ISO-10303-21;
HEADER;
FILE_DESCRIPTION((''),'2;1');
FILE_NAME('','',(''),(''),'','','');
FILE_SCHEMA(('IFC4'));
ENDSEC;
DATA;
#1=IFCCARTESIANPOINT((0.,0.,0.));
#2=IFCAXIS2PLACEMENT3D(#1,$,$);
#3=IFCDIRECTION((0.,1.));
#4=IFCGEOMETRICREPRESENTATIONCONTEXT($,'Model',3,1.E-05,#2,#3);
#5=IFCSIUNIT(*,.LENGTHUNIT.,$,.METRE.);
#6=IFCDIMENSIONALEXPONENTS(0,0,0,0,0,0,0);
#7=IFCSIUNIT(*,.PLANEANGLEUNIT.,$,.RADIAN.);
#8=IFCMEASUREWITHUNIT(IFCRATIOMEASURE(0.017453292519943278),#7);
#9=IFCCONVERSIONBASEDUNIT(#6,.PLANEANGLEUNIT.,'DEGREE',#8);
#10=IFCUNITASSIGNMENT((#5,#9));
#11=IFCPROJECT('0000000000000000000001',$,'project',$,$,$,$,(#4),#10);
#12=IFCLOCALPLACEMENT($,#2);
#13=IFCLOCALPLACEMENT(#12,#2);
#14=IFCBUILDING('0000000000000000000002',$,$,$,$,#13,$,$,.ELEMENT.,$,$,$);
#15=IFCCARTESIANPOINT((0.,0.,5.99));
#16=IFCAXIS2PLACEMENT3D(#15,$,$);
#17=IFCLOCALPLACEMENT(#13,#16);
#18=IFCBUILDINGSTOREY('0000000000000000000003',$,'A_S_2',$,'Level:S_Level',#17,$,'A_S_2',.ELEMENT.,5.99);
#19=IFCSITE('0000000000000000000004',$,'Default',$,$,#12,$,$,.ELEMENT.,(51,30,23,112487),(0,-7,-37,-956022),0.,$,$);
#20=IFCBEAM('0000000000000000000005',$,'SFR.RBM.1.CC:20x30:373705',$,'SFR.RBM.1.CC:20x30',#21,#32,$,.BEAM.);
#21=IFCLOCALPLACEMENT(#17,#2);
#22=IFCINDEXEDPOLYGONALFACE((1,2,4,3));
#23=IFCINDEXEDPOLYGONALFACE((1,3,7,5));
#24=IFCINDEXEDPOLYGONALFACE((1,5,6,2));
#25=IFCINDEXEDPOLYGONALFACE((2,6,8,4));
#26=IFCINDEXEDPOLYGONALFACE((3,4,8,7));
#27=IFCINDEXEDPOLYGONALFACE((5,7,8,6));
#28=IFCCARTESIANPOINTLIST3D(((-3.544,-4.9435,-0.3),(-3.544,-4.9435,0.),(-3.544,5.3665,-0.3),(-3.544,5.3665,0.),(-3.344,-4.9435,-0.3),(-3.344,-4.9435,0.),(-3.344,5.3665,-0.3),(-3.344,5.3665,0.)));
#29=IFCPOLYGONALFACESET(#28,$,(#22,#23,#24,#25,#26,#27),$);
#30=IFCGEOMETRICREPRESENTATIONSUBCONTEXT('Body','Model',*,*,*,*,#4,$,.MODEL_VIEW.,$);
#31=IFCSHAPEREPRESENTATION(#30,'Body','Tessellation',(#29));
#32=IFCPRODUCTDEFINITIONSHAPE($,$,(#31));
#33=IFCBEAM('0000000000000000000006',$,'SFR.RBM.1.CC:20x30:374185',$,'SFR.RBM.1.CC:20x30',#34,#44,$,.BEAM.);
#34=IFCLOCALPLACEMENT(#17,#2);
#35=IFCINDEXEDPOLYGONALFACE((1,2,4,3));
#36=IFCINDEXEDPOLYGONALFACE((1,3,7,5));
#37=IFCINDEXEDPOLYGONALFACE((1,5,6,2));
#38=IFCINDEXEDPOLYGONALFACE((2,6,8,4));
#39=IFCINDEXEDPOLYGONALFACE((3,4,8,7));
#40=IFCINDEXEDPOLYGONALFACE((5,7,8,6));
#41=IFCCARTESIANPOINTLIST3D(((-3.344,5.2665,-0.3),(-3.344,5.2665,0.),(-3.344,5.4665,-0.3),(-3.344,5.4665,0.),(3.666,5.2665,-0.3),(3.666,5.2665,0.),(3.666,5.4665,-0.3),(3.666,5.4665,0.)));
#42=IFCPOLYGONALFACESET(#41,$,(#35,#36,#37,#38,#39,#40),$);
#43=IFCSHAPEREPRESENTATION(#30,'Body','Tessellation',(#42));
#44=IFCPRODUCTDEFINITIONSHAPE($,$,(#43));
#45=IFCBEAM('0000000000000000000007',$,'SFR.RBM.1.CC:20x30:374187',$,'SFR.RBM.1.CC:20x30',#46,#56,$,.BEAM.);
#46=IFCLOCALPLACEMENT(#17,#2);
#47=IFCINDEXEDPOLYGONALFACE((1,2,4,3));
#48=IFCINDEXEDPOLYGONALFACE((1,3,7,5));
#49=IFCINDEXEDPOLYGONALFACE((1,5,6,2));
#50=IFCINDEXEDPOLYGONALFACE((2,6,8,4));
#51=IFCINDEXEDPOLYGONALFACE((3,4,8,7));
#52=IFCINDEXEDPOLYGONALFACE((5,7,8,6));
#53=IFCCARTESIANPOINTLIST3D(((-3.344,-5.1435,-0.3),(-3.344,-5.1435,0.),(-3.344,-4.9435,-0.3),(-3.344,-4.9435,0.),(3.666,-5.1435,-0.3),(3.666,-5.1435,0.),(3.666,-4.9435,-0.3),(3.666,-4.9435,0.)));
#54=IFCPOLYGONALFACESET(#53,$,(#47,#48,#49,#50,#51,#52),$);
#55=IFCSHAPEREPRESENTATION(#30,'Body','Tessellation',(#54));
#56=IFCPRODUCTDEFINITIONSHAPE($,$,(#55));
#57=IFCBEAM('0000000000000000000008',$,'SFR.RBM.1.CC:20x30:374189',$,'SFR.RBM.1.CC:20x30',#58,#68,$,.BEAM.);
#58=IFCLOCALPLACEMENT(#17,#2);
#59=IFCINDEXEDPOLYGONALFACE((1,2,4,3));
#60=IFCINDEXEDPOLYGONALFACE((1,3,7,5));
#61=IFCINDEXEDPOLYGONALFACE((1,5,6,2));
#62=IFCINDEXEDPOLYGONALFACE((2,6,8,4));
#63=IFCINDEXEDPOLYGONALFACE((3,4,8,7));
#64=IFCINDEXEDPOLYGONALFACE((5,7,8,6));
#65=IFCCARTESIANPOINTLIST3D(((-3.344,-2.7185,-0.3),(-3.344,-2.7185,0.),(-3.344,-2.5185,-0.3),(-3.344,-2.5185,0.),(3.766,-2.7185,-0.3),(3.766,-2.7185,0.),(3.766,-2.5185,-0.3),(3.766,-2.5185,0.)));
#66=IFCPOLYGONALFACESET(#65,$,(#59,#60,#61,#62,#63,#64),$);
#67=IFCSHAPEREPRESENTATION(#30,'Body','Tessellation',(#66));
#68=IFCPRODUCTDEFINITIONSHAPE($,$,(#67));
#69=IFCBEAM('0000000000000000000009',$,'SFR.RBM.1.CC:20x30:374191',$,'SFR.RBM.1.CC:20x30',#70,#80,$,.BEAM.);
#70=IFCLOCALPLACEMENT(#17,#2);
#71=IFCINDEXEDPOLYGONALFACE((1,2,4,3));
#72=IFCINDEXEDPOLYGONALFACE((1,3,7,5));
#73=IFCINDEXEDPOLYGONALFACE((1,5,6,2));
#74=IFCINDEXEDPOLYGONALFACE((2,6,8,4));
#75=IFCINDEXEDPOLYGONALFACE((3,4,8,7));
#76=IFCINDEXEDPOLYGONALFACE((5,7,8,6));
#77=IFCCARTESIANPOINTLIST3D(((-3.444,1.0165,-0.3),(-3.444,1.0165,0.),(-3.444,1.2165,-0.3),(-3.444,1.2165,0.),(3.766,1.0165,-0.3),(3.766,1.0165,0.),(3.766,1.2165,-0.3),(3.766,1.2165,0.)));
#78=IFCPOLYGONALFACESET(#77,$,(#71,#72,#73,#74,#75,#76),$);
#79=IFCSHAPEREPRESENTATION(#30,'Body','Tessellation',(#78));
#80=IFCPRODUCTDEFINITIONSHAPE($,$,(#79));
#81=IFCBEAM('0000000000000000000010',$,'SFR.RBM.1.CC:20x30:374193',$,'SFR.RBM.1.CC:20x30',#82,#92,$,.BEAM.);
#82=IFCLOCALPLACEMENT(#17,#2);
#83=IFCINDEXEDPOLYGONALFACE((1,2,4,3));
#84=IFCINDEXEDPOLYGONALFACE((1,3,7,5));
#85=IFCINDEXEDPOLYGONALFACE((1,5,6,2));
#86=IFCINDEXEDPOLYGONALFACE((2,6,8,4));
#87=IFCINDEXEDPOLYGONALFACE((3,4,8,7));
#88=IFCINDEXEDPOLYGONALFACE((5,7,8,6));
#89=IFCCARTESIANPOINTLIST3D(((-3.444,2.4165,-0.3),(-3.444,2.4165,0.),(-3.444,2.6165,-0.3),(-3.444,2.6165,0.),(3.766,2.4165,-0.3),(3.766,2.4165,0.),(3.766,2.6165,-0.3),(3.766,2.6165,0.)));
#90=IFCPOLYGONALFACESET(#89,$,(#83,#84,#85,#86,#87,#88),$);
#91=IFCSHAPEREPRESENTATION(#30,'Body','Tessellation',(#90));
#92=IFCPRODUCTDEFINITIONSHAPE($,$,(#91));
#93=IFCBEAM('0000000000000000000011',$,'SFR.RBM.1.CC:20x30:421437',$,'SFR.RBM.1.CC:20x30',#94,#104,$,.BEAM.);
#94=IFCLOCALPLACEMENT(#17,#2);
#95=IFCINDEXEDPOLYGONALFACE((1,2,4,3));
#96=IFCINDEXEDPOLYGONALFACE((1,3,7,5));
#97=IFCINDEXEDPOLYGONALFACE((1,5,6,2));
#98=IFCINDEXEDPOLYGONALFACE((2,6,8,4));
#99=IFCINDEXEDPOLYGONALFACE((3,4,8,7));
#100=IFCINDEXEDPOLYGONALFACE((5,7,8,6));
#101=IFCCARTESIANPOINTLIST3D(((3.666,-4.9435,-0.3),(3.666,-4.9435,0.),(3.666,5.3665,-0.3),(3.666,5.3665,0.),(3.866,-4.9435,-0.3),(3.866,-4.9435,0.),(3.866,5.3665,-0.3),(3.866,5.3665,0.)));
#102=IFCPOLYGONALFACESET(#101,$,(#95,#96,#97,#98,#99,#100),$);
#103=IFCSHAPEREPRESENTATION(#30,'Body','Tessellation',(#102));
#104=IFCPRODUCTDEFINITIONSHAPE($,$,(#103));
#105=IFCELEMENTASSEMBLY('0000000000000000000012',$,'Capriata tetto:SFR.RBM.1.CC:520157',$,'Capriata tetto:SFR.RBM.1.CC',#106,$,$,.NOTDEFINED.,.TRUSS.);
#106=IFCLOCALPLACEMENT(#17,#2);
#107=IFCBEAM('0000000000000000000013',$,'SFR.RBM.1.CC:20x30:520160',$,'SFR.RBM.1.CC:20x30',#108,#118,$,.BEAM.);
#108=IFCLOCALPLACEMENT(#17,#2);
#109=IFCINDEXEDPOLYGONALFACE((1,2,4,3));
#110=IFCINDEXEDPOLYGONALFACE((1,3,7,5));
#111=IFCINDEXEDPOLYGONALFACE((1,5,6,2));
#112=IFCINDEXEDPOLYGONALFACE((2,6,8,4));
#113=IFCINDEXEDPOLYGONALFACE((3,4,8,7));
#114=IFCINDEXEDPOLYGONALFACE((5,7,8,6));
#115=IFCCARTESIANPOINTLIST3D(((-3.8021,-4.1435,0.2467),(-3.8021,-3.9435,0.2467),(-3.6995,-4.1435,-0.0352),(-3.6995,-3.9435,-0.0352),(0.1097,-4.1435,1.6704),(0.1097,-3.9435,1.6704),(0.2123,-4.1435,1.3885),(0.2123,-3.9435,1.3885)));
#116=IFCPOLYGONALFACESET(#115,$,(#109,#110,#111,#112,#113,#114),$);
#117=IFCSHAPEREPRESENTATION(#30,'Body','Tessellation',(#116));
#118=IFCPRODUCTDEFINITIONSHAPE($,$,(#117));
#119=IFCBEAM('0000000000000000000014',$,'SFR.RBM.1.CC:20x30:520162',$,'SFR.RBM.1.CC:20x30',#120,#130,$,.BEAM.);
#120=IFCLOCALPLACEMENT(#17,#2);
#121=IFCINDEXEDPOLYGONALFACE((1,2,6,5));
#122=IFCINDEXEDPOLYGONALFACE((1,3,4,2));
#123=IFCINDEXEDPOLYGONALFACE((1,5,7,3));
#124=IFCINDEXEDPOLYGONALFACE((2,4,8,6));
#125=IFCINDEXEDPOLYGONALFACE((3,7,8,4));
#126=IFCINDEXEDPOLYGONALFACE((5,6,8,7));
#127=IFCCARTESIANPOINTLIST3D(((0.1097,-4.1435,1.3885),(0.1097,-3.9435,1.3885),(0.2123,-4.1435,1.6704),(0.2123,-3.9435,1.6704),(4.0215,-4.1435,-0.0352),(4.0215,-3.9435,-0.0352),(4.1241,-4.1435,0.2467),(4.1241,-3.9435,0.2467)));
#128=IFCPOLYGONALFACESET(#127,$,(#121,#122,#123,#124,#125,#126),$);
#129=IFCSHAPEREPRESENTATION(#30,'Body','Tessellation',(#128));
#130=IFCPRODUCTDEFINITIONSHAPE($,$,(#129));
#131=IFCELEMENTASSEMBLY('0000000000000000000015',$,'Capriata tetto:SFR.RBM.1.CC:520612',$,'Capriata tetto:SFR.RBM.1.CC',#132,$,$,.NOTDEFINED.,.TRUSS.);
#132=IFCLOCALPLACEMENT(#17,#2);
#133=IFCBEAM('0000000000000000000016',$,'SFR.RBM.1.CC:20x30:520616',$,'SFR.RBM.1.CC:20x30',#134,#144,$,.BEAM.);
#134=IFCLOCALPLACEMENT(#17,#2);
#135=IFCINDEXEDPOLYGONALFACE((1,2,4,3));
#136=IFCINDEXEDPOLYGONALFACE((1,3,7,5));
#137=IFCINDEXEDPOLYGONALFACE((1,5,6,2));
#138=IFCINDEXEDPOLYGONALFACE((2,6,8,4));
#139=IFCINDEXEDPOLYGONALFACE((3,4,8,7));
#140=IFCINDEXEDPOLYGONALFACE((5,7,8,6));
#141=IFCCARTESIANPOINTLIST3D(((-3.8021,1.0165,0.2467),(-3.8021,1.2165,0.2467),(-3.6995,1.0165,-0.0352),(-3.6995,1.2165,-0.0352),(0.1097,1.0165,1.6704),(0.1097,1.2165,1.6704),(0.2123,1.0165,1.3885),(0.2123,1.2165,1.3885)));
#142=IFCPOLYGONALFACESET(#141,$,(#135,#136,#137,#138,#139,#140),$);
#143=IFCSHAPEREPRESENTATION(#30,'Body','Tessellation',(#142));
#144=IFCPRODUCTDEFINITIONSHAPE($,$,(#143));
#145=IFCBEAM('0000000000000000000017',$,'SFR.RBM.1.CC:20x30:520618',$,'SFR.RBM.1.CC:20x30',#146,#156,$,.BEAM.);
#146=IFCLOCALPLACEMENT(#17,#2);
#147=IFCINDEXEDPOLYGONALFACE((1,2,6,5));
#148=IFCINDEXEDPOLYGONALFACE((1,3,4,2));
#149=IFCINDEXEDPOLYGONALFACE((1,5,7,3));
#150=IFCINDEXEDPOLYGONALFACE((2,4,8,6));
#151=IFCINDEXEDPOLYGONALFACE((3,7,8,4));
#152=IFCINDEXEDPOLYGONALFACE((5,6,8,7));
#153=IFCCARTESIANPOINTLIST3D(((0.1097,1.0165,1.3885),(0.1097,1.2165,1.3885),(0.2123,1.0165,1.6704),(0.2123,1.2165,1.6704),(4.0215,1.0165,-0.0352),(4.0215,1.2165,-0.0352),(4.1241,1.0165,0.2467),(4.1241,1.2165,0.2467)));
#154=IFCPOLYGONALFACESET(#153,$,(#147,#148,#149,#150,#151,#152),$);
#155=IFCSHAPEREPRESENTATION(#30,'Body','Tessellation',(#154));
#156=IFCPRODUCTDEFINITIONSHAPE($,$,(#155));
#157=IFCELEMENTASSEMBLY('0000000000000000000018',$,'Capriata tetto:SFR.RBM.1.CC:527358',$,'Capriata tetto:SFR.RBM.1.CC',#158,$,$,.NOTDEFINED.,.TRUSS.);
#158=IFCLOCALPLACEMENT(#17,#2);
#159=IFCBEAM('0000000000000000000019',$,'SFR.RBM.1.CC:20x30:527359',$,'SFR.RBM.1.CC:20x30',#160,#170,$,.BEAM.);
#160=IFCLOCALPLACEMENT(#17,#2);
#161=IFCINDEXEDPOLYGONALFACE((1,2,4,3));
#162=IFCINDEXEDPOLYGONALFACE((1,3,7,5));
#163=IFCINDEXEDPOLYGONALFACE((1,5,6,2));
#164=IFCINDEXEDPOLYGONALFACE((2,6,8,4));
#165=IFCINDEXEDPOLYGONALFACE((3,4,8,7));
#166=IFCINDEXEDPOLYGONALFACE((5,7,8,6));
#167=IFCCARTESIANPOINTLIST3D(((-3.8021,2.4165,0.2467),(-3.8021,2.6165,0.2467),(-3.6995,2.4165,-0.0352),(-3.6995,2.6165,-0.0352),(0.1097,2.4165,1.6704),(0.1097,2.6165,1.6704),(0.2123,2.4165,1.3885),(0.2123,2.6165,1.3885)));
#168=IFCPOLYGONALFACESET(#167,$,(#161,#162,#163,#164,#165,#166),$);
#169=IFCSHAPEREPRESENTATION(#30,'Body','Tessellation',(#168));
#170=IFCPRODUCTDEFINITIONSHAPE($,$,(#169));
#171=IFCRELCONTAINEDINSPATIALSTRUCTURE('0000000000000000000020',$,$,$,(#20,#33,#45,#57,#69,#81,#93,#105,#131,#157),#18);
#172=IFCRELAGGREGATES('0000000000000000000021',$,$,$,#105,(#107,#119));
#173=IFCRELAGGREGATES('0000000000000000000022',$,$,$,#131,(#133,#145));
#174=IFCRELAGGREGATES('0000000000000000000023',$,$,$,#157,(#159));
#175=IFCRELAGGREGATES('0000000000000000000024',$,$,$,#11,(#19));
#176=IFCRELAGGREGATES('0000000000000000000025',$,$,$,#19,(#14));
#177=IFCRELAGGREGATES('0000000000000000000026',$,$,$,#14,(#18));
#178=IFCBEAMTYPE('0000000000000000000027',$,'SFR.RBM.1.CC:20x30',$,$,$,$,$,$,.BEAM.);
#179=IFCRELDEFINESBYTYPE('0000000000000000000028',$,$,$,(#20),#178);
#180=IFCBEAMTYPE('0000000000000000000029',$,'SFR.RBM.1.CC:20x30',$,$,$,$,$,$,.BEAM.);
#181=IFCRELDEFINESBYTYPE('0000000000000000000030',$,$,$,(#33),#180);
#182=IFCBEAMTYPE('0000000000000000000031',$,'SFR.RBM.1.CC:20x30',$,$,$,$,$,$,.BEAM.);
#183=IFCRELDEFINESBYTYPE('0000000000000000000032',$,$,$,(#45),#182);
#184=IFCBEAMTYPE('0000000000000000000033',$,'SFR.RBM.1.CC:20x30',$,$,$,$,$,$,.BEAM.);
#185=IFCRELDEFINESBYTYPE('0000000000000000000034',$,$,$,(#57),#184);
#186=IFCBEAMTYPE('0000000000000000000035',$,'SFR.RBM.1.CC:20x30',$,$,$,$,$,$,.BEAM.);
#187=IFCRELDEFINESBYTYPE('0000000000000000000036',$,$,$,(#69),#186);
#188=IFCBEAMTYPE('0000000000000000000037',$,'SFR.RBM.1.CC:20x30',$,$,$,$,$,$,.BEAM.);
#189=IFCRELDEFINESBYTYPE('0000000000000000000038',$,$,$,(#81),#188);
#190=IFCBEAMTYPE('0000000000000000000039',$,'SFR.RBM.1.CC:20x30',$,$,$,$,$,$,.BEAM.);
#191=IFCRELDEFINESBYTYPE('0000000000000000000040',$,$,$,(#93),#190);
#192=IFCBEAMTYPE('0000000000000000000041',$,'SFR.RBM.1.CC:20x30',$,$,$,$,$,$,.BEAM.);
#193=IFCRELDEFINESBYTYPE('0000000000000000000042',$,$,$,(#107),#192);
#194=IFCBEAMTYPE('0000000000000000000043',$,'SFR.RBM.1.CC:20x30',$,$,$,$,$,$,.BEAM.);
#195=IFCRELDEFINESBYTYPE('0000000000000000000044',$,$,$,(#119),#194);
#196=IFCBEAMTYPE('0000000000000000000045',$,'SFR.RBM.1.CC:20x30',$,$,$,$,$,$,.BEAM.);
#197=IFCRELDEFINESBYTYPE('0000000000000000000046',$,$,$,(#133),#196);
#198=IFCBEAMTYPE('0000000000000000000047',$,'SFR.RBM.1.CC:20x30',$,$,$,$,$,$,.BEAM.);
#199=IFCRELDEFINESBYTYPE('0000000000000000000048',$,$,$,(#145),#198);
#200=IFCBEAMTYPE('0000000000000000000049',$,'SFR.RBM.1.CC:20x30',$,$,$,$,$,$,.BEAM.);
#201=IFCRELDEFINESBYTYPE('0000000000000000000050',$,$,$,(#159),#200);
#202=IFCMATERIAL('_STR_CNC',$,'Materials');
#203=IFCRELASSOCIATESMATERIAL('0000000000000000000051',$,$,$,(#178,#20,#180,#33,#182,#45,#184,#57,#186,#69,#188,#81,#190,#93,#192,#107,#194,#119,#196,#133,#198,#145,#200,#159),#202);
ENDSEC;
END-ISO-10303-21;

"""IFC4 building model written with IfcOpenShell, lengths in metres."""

from ifc_helpers import new_model, entity, si_unit, converted_unit, direction, frame, origin, place, context, subcontext, project, spatial, indexed_curve, outline, extrude, source, transform, mapped, material, type_object, type_shapes, element, aggregate, save


model = new_model("IFC4")

# Units and contexts
model_context = context("Model", 3, precision=1e-05, world=origin(), true_north=direction((0.0, 1.0)))
body_context = subcontext(model_context, "Body", "Model", "MODEL_VIEW")
ifc_project = project(units=[si_unit("LENGTHUNIT", "METRE"), converted_unit("PLANEANGLEUNIT", "DEGREE", entity("IfcRatioMeasure", 0.017453292519943278), si_unit("PLANEANGLEUNIT", "RADIAN"), dimensions=[0, 0, 0, 0, 0, 0, 0])], contexts=[model_context])

# Site, building, storey
site_placement = place(None, origin())
site = spatial("IfcSite", under=ifc_project, at=site_placement, Name="Default", CompositionType="ELEMENT", RefLatitude=(51, 30, 23, 112487), RefLongitude=(0, -7, -37, -956022), RefElevation=0.0)
building_placement = place(site_placement, origin())
building = spatial("IfcBuilding", under=site, at=building_placement, CompositionType="ELEMENT")
storey_placement = place(building_placement, frame((0.0, 0.0, 5.99)))
storey = spatial("IfcBuildingStorey", under=building, at=storey_placement, Name="A_S_2", ObjectType="Level:S_Level", LongName="A_S_2", CompositionType="ELEMENT", Elevation=5.99)

# Beams
ifc_material_1 = material(Name="_STR_CNC", Category="Materials")
beam_type_1 = type_object("IfcBeamType", Name="SFR.RBM.1.CC:20x30", PredefinedType="BEAM", material=ifc_material_1)
shared_shape_1 = source(origin(), body_context, "Body", "SweptSolid", [
    extrude(outline(indexed_curve([(-0.1, -0.15), (0.1, -0.15), (0.1, 0.15), (-0.1, 0.15), (-0.1, -0.15)], self_intersect=False)), frame((-3.444, 5.3665, 5.84), z_axis=(0.0, -1.0, 0.0), x_axis=(-1.0, 0.0, 0.0)), (0.0, 0.0, 1.0), 10.31),
])
type_shapes(beam_type_1, [shared_shape_1])
beam_1_placement = place(storey_placement, frame((0.0, 0.0, -5.99)))
element("IfcBeam", 1, at=beam_1_placement, inside=storey, type_object=beam_type_1, material=ifc_material_1, Name="SFR.RBM.1.CC:20x30:373705", ObjectType="SFR.RBM.1.CC:20x30", PredefinedType="BEAM", context=body_context, shape_type="MappedRepresentation", body=[
    mapped(shared_shape_1, transform((0.0, 0.0, 0.0), scale=1.0)),
])
beam_type_2 = type_object("IfcBeamType", Name="SFR.RBM.1.CC:20x30", PredefinedType="BEAM", material=ifc_material_1)
shared_shape_2 = source(origin(), body_context, "Body", "SweptSolid", [
    extrude(outline(indexed_curve([(-0.15, -0.1), (0.15, -0.1), (0.15, 0.1), (-0.15, 0.1), (-0.15, -0.1)], self_intersect=False)), frame((3.666, 5.3665, 5.84), z_axis=(-1.0, 0.0, 0.0), x_axis=(0.0, 0.0, -1.0)), (0.0, 0.0, 1.0), 7.01),
])
type_shapes(beam_type_2, [shared_shape_2])
beam_2_placement = place(storey_placement, frame((0.0, 0.0, -5.99)))
element("IfcBeam", 2, at=beam_2_placement, inside=storey, type_object=beam_type_2, material=ifc_material_1, Name="SFR.RBM.1.CC:20x30:374185", ObjectType="SFR.RBM.1.CC:20x30", PredefinedType="BEAM", context=body_context, shape_type="MappedRepresentation", body=[
    mapped(shared_shape_2, transform((0.0, 0.0, 0.0), scale=1.0)),
])
beam_type_3 = type_object("IfcBeamType", Name="SFR.RBM.1.CC:20x30", PredefinedType="BEAM", material=ifc_material_1)
shared_shape_3 = source(origin(), body_context, "Body", "SweptSolid", [
    extrude(outline(indexed_curve([(-0.15, -0.1), (0.15, -0.1), (0.15, 0.1), (-0.15, 0.1), (-0.15, -0.1)], self_intersect=False)), frame((3.666, -5.0435, 5.84), z_axis=(-1.0, 0.0, 0.0), x_axis=(0.0, 0.0, -1.0)), (0.0, 0.0, 1.0), 7.01),
])
type_shapes(beam_type_3, [shared_shape_3])
beam_3_placement = place(storey_placement, frame((0.0, 0.0, -5.99)))
element("IfcBeam", 3, at=beam_3_placement, inside=storey, type_object=beam_type_3, material=ifc_material_1, Name="SFR.RBM.1.CC:20x30:374187", ObjectType="SFR.RBM.1.CC:20x30", PredefinedType="BEAM", context=body_context, shape_type="MappedRepresentation", body=[
    mapped(shared_shape_3, transform((0.0, 0.0, 0.0), scale=1.0)),
])
beam_type_4 = type_object("IfcBeamType", Name="SFR.RBM.1.CC:20x30", PredefinedType="BEAM", material=ifc_material_1)
shared_shape_4 = source(origin(), body_context, "Body", "SweptSolid", [
    extrude(outline(indexed_curve([(-0.15, -0.1), (0.15, -0.1), (0.15, 0.1), (-0.15, 0.1), (-0.15, -0.1)], self_intersect=False)), frame((3.766, -2.6185, 5.84), z_axis=(-1.0, 0.0, 0.0), x_axis=(0.0, 0.0, -1.0)), (0.0, 0.0, 1.0), 7.11),
])
type_shapes(beam_type_4, [shared_shape_4])
beam_4_placement = place(storey_placement, frame((0.0, 0.0, -5.99)))
element("IfcBeam", 4, at=beam_4_placement, inside=storey, type_object=beam_type_4, material=ifc_material_1, Name="SFR.RBM.1.CC:20x30:374189", ObjectType="SFR.RBM.1.CC:20x30", PredefinedType="BEAM", context=body_context, shape_type="MappedRepresentation", body=[
    mapped(shared_shape_4, transform((0.0, 0.0, 0.0), scale=1.0)),
])
beam_type_5 = type_object("IfcBeamType", Name="SFR.RBM.1.CC:20x30", PredefinedType="BEAM", material=ifc_material_1)
shared_shape_5 = source(origin(), body_context, "Body", "SweptSolid", [
    extrude(outline(indexed_curve([(-0.15, -0.1), (0.15, -0.1), (0.15, 0.1), (-0.15, 0.1), (-0.15, -0.1)], self_intersect=False)), frame((3.766, 1.1165, 5.84), z_axis=(-1.0, 0.0, 0.0), x_axis=(0.0, 0.0, -1.0)), (0.0, 0.0, 1.0), 7.21),
])
type_shapes(beam_type_5, [shared_shape_5])
beam_5_placement = place(storey_placement, frame((0.0, 0.0, -5.99)))
element("IfcBeam", 5, at=beam_5_placement, inside=storey, type_object=beam_type_5, material=ifc_material_1, Name="SFR.RBM.1.CC:20x30:374191", ObjectType="SFR.RBM.1.CC:20x30", PredefinedType="BEAM", context=body_context, shape_type="MappedRepresentation", body=[
    mapped(shared_shape_5, transform((0.0, 0.0, 0.0), scale=1.0)),
])
beam_type_6 = type_object("IfcBeamType", Name="SFR.RBM.1.CC:20x30", PredefinedType="BEAM", material=ifc_material_1)
shared_shape_6 = source(origin(), body_context, "Body", "SweptSolid", [
    extrude(outline(indexed_curve([(-0.15, -0.1), (0.15, -0.1), (0.15, 0.1), (-0.15, 0.1), (-0.15, -0.1)], self_intersect=False)), frame((3.766, 2.5165, 5.84), z_axis=(-1.0, 0.0, 0.0), x_axis=(0.0, 0.0, -1.0)), (0.0, 0.0, 1.0), 7.21),
])
type_shapes(beam_type_6, [shared_shape_6])
beam_6_placement = place(storey_placement, frame((0.0, 0.0, -5.99)))
element("IfcBeam", 6, at=beam_6_placement, inside=storey, type_object=beam_type_6, material=ifc_material_1, Name="SFR.RBM.1.CC:20x30:374193", ObjectType="SFR.RBM.1.CC:20x30", PredefinedType="BEAM", context=body_context, shape_type="MappedRepresentation", body=[
    mapped(shared_shape_6, transform((0.0, 0.0, 0.0), scale=1.0)),
])
beam_type_7 = type_object("IfcBeamType", Name="SFR.RBM.1.CC:20x30", PredefinedType="BEAM", material=ifc_material_1)
shared_shape_7 = source(origin(), body_context, "Body", "SweptSolid", [
    extrude(outline(indexed_curve([(-0.1, -0.15), (0.1, -0.15), (0.1, 0.15), (-0.1, 0.15), (-0.1, -0.15)], self_intersect=False)), frame((3.766, 5.3665, 5.84), z_axis=(0.0, -1.0, 0.0), x_axis=(-1.0, 0.0, 0.0)), (0.0, 0.0, 1.0), 10.31),
])
type_shapes(beam_type_7, [shared_shape_7])
beam_7_placement = place(storey_placement, frame((0.0, 0.0, -5.99)))
element("IfcBeam", 7, at=beam_7_placement, inside=storey, type_object=beam_type_7, material=ifc_material_1, Name="SFR.RBM.1.CC:20x30:421437", ObjectType="SFR.RBM.1.CC:20x30", PredefinedType="BEAM", context=body_context, shape_type="MappedRepresentation", body=[
    mapped(shared_shape_7, transform((0.0, 0.0, 0.0), scale=1.0)),
])

# Element assemblies, beams
assembly_1_placement = place(storey_placement, origin())
assembly_1 = element("IfcElementAssembly", 8, at=assembly_1_placement, inside=storey, Name="Capriata tetto:SFR.RBM.1.CC:520157", ObjectType="Capriata tetto:SFR.RBM.1.CC", AssemblyPlace="NOTDEFINED", PredefinedType="TRUSS")
beam_type_8 = type_object("IfcBeamType", Name="SFR.RBM.1.CC:20x30", PredefinedType="BEAM", material=ifc_material_1)
shared_shape_8 = source(origin(), body_context, "Body", "SweptSolid", [
    extrude(outline(indexed_curve([(-0.1, -0.15), (0.1, -0.15), (0.1, 0.15), (-0.1, 0.15), (-0.1, -0.15)], self_intersect=False)), frame((-3.7508, -4.0435, 6.0957), z_axis=(0.939693, 0.0, 0.34202), x_axis=(0.0, -1.0, 0.0)), (0.0, 0.0, 1.0), 4.1628),
])
type_shapes(beam_type_8, [shared_shape_8])
beam_8_placement = place(assembly_1_placement, frame((0.0, 0.0, -5.99)))
beam_8 = element("IfcBeam", 9, at=beam_8_placement, type_object=beam_type_8, material=ifc_material_1, Name="SFR.RBM.1.CC:20x30:520160", ObjectType="SFR.RBM.1.CC:20x30", PredefinedType="BEAM", context=body_context, shape_type="MappedRepresentation", body=[
    mapped(shared_shape_8, transform((0.0, 0.0, 0.0), scale=1.0)),
])
beam_type_9 = type_object("IfcBeamType", Name="SFR.RBM.1.CC:20x30", PredefinedType="BEAM", material=ifc_material_1)
shared_shape_9 = source(origin(), body_context, "Body", "SweptSolid", [
    extrude(outline(indexed_curve([(-0.1, -0.15), (0.1, -0.15), (0.1, 0.15), (-0.1, 0.15), (-0.1, -0.15)], self_intersect=False)), frame((0.161, -4.0435, 7.5195), z_axis=(0.939693, 0.0, -0.34202), x_axis=(0.0, 1.0, 0.0)), (0.0, 0.0, 1.0), 4.1628),
])
type_shapes(beam_type_9, [shared_shape_9])
beam_9_placement = place(assembly_1_placement, frame((0.0, 0.0, -5.99)))
beam_9 = element("IfcBeam", 10, at=beam_9_placement, type_object=beam_type_9, material=ifc_material_1, Name="SFR.RBM.1.CC:20x30:520162", ObjectType="SFR.RBM.1.CC:20x30", PredefinedType="BEAM", context=body_context, shape_type="MappedRepresentation", body=[
    mapped(shared_shape_9, transform((0.0, 0.0, 0.0), scale=1.0)),
])
aggregate(assembly_1, [beam_8, beam_9])
assembly_2_placement = place(storey_placement, origin())
assembly_2 = element("IfcElementAssembly", 11, at=assembly_2_placement, inside=storey, Name="Capriata tetto:SFR.RBM.1.CC:520612", ObjectType="Capriata tetto:SFR.RBM.1.CC", AssemblyPlace="NOTDEFINED", PredefinedType="TRUSS")
beam_type_10 = type_object("IfcBeamType", Name="SFR.RBM.1.CC:20x30", PredefinedType="BEAM", material=ifc_material_1)
shared_shape_10 = source(origin(), body_context, "Body", "SweptSolid", [
    extrude(outline(indexed_curve([(-0.1, -0.15), (0.1, -0.15), (0.1, 0.15), (-0.1, 0.15), (-0.1, -0.15)], self_intersect=False)), frame((-3.7508, 1.1165, 6.0957), z_axis=(0.939693, 0.0, 0.34202), x_axis=(0.0, -1.0, 0.0)), (0.0, 0.0, 1.0), 4.1628),
])
type_shapes(beam_type_10, [shared_shape_10])
beam_10_placement = place(assembly_2_placement, frame((0.0, 0.0, -5.99)))
beam_10 = element("IfcBeam", 12, at=beam_10_placement, type_object=beam_type_10, material=ifc_material_1, Name="SFR.RBM.1.CC:20x30:520616", ObjectType="SFR.RBM.1.CC:20x30", PredefinedType="BEAM", context=body_context, shape_type="MappedRepresentation", body=[
    mapped(shared_shape_10, transform((0.0, 0.0, 0.0), scale=1.0)),
])
beam_type_11 = type_object("IfcBeamType", Name="SFR.RBM.1.CC:20x30", PredefinedType="BEAM", material=ifc_material_1)
shared_shape_11 = source(origin(), body_context, "Body", "SweptSolid", [
    extrude(outline(indexed_curve([(-0.1, -0.15), (0.1, -0.15), (0.1, 0.15), (-0.1, 0.15), (-0.1, -0.15)], self_intersect=False)), frame((0.161, 1.1165, 7.5195), z_axis=(0.939693, 0.0, -0.34202), x_axis=(0.0, 1.0, 0.0)), (0.0, 0.0, 1.0), 4.1628),
])
type_shapes(beam_type_11, [shared_shape_11])
beam_11_placement = place(assembly_2_placement, frame((0.0, 0.0, -5.99)))
beam_11 = element("IfcBeam", 13, at=beam_11_placement, type_object=beam_type_11, material=ifc_material_1, Name="SFR.RBM.1.CC:20x30:520618", ObjectType="SFR.RBM.1.CC:20x30", PredefinedType="BEAM", context=body_context, shape_type="MappedRepresentation", body=[
    mapped(shared_shape_11, transform((0.0, 0.0, 0.0), scale=1.0)),
])
aggregate(assembly_2, [beam_10, beam_11])
assembly_3_placement = place(storey_placement, origin())
assembly_3 = element("IfcElementAssembly", 14, at=assembly_3_placement, inside=storey, Name="Capriata tetto:SFR.RBM.1.CC:527358", ObjectType="Capriata tetto:SFR.RBM.1.CC", AssemblyPlace="NOTDEFINED", PredefinedType="TRUSS")
beam_type_12 = type_object("IfcBeamType", Name="SFR.RBM.1.CC:20x30", PredefinedType="BEAM", material=ifc_material_1)
shared_shape_12 = source(origin(), body_context, "Body", "SweptSolid", [
    extrude(outline(indexed_curve([(-0.1, -0.15), (0.1, -0.15), (0.1, 0.15), (-0.1, 0.15), (-0.1, -0.15)], self_intersect=False)), frame((-3.7508, 2.5165, 6.0957), z_axis=(0.939693, 0.0, 0.34202), x_axis=(0.0, -1.0, 0.0)), (0.0, 0.0, 1.0), 4.1628),
])
type_shapes(beam_type_12, [shared_shape_12])
beam_12_placement = place(assembly_3_placement, frame((0.0, 0.0, -5.99)))
beam_12 = element("IfcBeam", 15, at=beam_12_placement, type_object=beam_type_12, material=ifc_material_1, Name="SFR.RBM.1.CC:20x30:527359", ObjectType="SFR.RBM.1.CC:20x30", PredefinedType="BEAM", context=body_context, shape_type="MappedRepresentation", body=[
    mapped(shared_shape_12, transform((0.0, 0.0, 0.0), scale=1.0)),
])
aggregate(assembly_3, [beam_12])

save(model, "model.ifc")
